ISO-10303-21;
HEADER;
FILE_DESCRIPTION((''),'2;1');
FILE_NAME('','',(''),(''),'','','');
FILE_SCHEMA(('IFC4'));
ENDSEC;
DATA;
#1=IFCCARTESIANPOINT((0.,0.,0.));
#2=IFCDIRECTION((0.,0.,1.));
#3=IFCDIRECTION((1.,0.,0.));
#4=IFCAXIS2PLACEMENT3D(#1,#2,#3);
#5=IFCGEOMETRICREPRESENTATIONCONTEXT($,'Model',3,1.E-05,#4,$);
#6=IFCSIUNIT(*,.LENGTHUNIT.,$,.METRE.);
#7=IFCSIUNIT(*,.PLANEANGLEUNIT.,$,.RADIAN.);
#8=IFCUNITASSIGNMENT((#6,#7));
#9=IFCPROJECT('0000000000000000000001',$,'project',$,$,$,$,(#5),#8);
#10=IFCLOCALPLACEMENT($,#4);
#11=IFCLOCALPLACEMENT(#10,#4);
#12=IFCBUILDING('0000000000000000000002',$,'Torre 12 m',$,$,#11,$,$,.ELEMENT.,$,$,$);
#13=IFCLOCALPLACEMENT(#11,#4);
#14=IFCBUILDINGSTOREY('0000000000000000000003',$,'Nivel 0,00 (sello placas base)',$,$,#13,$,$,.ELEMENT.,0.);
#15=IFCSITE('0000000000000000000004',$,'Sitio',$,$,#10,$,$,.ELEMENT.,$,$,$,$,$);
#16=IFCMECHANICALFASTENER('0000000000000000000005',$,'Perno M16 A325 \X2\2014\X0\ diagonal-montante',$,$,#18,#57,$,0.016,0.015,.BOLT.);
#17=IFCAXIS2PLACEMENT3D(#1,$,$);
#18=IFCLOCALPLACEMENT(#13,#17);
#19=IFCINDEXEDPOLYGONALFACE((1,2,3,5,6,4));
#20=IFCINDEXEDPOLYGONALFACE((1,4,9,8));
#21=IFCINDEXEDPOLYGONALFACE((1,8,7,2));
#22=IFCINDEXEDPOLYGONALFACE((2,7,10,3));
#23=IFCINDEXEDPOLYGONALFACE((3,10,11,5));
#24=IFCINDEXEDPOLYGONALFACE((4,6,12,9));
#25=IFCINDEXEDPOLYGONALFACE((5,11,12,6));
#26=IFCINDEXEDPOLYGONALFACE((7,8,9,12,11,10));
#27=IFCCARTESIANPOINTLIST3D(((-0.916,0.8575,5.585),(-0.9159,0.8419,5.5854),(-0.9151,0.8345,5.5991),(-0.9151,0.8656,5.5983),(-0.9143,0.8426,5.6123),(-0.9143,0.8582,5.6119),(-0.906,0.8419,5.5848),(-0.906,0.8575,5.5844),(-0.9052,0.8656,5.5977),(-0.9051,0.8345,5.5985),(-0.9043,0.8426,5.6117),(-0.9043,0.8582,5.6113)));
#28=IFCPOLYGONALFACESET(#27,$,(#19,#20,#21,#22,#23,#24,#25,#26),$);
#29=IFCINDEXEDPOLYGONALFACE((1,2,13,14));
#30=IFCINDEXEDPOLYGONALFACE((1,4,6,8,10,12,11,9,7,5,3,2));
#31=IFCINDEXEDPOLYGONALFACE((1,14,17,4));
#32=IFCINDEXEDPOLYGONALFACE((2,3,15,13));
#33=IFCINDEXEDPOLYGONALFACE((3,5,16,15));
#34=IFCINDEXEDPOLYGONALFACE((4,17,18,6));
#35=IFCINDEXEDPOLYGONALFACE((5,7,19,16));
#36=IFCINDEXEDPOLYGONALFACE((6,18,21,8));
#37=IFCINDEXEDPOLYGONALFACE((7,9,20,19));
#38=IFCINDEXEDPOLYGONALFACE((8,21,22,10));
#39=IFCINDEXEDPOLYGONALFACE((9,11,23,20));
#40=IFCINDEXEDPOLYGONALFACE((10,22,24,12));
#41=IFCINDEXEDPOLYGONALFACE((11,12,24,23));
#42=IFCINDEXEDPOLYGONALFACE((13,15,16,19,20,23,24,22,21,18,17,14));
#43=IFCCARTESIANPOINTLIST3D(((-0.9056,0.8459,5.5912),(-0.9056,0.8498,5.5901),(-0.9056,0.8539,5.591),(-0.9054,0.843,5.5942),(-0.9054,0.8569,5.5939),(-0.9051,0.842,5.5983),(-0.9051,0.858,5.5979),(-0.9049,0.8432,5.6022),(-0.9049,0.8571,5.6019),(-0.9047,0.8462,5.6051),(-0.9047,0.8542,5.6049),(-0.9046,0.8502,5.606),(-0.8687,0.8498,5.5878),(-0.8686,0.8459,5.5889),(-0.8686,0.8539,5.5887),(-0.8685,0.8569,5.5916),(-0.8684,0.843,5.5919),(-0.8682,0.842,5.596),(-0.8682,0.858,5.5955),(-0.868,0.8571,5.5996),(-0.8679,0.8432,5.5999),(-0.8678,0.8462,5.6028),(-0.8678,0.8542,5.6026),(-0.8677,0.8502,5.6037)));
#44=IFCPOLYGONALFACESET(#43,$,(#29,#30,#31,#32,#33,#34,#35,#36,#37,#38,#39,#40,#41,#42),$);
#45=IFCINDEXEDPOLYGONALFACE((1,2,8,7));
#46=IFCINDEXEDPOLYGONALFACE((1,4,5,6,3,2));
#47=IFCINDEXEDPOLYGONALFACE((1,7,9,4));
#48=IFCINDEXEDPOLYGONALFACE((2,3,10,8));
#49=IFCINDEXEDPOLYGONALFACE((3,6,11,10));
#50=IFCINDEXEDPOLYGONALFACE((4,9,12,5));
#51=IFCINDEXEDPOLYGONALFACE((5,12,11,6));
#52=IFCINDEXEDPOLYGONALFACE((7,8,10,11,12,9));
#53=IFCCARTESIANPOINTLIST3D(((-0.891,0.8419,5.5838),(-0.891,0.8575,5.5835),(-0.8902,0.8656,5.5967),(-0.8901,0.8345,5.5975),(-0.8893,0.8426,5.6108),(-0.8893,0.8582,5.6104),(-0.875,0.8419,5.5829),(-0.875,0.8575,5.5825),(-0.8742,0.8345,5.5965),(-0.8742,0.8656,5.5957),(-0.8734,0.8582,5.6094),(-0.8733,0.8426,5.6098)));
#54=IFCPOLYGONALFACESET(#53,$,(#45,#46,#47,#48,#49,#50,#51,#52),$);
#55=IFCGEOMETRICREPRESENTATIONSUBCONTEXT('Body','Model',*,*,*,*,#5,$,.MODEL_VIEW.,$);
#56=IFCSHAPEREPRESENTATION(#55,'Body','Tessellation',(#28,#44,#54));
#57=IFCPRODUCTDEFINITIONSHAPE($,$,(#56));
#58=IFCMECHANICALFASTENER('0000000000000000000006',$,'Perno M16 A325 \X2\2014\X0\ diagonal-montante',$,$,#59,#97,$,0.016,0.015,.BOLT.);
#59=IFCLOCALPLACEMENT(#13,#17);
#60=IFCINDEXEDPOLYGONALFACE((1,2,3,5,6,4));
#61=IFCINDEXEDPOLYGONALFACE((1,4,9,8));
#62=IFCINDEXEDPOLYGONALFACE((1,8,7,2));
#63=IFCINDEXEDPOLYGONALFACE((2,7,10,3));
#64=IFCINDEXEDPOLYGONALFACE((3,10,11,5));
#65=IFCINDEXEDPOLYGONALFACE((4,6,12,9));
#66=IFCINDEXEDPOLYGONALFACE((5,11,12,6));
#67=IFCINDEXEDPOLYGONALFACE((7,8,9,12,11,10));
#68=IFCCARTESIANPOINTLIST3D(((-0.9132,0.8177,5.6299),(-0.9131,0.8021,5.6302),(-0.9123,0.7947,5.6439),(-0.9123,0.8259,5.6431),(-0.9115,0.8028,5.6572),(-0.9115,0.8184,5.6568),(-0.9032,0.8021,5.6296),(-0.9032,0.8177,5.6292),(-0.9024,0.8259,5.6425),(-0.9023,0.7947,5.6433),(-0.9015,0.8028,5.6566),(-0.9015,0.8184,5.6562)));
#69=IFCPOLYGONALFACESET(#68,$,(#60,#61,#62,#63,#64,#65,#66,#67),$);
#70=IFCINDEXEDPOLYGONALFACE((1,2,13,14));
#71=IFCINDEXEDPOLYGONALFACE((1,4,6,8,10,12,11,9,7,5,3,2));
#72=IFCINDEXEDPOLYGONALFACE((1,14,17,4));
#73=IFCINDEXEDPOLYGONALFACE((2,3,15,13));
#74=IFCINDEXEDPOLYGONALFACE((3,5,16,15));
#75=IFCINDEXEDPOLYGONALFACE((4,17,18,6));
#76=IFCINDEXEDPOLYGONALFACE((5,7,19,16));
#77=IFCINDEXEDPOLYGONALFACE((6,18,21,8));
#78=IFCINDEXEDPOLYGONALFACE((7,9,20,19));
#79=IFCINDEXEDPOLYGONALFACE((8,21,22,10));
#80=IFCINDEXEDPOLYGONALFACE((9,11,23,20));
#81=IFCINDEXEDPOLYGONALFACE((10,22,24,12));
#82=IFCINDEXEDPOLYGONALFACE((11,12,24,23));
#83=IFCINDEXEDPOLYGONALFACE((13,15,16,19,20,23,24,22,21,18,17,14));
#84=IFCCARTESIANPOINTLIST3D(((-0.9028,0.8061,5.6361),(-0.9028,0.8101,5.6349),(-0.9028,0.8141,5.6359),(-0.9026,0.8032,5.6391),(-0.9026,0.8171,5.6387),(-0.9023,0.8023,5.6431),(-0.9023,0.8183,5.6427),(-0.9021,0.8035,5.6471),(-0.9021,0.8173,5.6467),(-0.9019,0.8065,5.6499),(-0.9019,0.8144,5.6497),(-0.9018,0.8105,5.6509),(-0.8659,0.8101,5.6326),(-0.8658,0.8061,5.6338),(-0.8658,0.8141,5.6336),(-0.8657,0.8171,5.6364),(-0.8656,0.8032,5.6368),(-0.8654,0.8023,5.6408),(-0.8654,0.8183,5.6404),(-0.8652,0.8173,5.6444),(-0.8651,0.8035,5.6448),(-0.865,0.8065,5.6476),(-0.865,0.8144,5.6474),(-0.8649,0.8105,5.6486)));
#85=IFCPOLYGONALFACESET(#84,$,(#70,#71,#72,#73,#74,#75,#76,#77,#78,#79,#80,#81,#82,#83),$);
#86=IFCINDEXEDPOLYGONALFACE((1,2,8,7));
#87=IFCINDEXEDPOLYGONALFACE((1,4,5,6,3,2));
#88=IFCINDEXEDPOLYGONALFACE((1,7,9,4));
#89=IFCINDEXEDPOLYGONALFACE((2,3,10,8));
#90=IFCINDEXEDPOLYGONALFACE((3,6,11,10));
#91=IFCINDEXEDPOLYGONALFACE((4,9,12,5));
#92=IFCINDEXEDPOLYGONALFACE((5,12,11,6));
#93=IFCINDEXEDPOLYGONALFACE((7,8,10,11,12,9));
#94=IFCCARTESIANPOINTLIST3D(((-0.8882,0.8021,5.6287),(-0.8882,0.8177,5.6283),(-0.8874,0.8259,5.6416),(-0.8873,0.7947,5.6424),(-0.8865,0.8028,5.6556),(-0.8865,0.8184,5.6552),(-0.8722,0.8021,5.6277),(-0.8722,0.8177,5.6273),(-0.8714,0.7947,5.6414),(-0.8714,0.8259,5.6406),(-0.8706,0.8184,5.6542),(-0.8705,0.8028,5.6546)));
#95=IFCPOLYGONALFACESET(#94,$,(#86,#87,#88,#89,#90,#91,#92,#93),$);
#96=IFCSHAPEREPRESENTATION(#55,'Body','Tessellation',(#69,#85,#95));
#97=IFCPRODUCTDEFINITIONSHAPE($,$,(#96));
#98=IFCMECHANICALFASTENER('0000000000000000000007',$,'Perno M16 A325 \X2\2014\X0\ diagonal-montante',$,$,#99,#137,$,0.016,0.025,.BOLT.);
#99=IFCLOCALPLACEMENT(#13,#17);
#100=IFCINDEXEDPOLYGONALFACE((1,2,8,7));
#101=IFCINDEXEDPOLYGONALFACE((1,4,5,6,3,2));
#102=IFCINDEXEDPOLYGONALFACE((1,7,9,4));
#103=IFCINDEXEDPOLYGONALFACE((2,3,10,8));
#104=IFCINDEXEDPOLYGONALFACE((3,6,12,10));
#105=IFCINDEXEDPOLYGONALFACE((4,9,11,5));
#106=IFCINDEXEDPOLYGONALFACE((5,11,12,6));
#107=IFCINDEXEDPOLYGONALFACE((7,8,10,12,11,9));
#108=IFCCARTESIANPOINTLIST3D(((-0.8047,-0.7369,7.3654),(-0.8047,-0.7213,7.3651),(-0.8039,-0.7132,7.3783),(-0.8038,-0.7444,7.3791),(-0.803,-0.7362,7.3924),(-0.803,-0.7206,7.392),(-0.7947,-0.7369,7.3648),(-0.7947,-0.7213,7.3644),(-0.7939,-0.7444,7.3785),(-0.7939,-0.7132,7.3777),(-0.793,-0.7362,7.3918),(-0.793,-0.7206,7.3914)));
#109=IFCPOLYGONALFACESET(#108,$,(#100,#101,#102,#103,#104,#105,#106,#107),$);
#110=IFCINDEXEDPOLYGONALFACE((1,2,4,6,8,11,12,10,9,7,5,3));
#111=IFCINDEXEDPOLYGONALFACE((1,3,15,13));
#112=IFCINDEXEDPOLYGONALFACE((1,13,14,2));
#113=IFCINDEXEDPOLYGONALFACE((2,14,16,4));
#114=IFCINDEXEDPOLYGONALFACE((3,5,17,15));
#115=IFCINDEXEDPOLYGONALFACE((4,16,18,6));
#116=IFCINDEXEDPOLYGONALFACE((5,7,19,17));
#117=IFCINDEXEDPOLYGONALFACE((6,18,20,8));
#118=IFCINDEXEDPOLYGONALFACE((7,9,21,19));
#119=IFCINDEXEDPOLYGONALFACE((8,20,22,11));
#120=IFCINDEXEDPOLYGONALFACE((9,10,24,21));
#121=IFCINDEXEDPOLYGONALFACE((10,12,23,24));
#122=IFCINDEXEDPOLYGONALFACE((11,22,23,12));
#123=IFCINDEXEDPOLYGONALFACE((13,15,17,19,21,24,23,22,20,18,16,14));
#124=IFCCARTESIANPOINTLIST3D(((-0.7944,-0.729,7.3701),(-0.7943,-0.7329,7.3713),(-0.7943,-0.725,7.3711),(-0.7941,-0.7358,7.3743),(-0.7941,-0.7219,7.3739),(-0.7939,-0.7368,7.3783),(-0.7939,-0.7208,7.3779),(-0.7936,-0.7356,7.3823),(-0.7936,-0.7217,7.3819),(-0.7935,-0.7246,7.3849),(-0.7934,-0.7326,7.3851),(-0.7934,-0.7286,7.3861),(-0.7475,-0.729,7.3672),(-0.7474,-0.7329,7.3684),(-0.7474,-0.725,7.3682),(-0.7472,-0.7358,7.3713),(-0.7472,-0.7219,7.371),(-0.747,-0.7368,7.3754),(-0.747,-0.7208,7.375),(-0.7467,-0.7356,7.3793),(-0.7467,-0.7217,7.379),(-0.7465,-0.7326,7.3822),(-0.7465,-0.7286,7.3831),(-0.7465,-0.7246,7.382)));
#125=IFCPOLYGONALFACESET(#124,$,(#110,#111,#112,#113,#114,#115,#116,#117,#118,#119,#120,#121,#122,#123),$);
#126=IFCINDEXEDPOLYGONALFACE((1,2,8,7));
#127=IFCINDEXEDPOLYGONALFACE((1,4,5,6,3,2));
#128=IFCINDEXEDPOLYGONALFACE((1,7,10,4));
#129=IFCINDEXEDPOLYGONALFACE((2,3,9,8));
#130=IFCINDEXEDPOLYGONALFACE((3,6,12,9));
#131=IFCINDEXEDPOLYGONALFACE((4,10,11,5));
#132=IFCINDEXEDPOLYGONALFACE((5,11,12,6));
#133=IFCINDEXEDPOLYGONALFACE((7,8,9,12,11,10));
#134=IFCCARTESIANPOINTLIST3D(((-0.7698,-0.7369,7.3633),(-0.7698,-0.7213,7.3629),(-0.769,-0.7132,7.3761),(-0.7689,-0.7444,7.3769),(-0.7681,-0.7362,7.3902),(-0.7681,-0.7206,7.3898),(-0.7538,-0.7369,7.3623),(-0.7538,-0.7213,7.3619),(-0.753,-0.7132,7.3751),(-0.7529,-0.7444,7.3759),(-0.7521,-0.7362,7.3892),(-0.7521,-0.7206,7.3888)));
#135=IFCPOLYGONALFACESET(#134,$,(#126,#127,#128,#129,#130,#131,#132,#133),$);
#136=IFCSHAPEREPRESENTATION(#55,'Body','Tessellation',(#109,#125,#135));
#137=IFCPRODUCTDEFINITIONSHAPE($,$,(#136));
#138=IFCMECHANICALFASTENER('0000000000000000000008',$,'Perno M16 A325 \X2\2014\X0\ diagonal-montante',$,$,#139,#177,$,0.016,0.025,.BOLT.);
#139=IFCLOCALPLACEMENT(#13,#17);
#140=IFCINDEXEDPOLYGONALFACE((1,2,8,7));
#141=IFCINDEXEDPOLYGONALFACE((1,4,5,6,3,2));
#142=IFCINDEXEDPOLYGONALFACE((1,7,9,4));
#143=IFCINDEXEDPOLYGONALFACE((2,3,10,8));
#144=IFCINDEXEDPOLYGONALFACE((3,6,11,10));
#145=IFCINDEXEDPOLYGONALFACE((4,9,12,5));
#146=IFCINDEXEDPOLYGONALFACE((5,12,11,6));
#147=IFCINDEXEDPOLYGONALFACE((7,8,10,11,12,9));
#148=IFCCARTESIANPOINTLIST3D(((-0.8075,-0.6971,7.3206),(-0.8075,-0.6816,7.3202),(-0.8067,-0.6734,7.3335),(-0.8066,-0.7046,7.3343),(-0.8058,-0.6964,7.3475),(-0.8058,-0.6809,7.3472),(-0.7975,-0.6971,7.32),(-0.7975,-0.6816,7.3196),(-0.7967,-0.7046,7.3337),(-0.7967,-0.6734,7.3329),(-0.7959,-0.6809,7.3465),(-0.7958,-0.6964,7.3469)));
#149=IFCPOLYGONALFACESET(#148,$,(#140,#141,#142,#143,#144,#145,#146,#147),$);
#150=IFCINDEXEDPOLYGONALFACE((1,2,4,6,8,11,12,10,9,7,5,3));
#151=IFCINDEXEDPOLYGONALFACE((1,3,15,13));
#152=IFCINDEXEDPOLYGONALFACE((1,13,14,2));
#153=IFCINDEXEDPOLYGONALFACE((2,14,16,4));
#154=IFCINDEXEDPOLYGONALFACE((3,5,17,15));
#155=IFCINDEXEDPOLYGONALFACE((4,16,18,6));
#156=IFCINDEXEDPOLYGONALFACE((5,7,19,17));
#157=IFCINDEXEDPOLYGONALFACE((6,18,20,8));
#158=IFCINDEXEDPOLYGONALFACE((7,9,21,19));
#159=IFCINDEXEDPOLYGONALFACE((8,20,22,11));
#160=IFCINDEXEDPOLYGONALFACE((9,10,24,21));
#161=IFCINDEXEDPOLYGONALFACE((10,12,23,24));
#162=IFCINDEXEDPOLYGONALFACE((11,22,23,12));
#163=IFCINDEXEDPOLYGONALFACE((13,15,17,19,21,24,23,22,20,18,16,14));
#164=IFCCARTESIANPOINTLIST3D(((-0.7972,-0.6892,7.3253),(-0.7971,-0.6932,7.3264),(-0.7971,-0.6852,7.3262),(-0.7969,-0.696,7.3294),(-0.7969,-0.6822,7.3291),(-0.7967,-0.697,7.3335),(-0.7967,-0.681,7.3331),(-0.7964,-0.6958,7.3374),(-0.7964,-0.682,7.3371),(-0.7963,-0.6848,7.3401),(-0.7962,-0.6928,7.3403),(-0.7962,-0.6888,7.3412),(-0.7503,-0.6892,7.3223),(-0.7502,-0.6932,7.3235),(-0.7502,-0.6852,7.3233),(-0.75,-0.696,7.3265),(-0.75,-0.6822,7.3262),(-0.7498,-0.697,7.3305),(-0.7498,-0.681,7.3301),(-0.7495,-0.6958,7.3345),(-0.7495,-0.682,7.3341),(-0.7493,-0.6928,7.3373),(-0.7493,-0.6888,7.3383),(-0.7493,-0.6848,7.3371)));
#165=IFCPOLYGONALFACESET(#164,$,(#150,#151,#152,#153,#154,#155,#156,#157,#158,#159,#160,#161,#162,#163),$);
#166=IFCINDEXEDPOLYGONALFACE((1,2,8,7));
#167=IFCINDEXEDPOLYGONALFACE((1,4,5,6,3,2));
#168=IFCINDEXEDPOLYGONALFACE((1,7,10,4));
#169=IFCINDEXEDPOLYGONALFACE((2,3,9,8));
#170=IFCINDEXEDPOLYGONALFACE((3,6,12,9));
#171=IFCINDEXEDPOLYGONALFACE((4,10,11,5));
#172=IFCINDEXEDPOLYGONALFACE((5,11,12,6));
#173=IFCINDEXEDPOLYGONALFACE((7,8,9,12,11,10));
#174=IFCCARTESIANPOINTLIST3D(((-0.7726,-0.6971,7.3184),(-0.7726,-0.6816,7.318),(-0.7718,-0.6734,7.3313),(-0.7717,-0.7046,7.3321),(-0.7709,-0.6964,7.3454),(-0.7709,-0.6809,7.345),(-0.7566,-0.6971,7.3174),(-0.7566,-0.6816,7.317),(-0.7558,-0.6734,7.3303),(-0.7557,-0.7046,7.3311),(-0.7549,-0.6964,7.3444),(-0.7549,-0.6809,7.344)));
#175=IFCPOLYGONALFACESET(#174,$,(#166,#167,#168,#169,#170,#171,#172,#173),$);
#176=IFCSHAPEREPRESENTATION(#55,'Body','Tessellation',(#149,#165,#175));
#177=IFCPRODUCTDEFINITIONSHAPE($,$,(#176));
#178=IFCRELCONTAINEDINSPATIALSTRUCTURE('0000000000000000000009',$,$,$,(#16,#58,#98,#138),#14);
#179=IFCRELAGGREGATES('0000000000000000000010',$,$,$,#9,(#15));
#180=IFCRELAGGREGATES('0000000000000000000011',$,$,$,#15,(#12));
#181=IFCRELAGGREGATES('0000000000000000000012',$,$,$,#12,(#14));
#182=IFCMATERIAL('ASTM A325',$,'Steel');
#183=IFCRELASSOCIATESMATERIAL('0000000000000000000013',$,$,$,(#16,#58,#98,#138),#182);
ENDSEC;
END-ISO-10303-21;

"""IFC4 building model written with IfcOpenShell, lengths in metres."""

from ifc_helpers import new_model, si_unit, frame, origin_with_axes, place, context, subcontext, project, spatial, polyline, outline, extrude, material, element, save


model = new_model("IFC4")

# Units and contexts
model_context = context("Model", 3, precision=1e-05, world=origin_with_axes())
body_context = subcontext(model_context, "Body", "Model", "MODEL_VIEW")
ifc_project = project(units=[si_unit("LENGTHUNIT", "METRE"), si_unit("PLANEANGLEUNIT", "RADIAN")], contexts=[model_context])

# Site, building, storey
site_placement = place(None, origin_with_axes())
site = spatial("IfcSite", under=ifc_project, at=site_placement, Name="Sitio", CompositionType="ELEMENT")
building_placement = place(site_placement, origin_with_axes())
building = spatial("IfcBuilding", under=site, at=building_placement, Name="Torre 12 m", CompositionType="ELEMENT")
storey_placement = place(building_placement, origin_with_axes())
storey = spatial("IfcBuildingStorey", under=building, at=storey_placement, Name="Nivel 0,00 (sello placas base)", CompositionType="ELEMENT", Elevation=0.0)

# Shared definitions
placement = place(storey_placement, origin_with_axes())

# Mechanical fasteners
ifc_material_1 = material(Name="ASTM A325", Category="Steel")
element("IfcMechanicalFastener", 1, at=placement, inside=storey, material=ifc_material_1, Name="Perno M16 A325 — diagonal-montante", NominalDiameter=0.016, NominalLength=0.015, PredefinedType="BOLT", context=body_context, shape_type="SweptSolid", body=[
    extrude(outline(polyline([(0.0135, 0.0078), (0.0, 0.0156), (-0.0135, 0.0078), (-0.0135, -0.0078), (0.0, -0.0156), (0.0135, -0.0078), (0.0135, 0.0078)])), frame((-0.9151, 0.85, 5.5987), z_axis=(0.998053, 0.0, -0.062378), x_axis=(0.032557, -0.85299, 0.52091)), (0.0, 0.0, 1.0), 0.01),
    extrude(outline(polyline([(0.008, 0.0), (0.0069, 0.004), (0.004, 0.0069), (0.0, 0.008), (-0.004, 0.0069), (-0.0069, 0.004), (-0.008, 0.0), (-0.0069, -0.004), (-0.004, -0.0069), (0.0, -0.008), (0.004, -0.0069), (0.0069, -0.004), (0.008, 0.0)])), frame((-0.9051, 0.85, 5.5981), z_axis=(0.998053, 0.0, -0.062378), x_axis=(0.032557, -0.85299, 0.52091)), (0.0, 0.0, 1.0), 0.037),
    extrude(outline(polyline([(0.0135, 0.0078), (0.0, 0.0156), (-0.0135, 0.0078), (-0.0135, -0.0078), (0.0, -0.0156), (0.0135, -0.0078), (0.0135, 0.0078)])), frame((-0.8902, 0.85, 5.5971), z_axis=(0.998053, 0.0, -0.062378), x_axis=(0.032557, -0.85299, 0.52091)), (0.0, 0.0, 1.0), 0.016),
])
element("IfcMechanicalFastener", 2, at=placement, inside=storey, material=ifc_material_1, Name="Perno M16 A325 — diagonal-montante", NominalDiameter=0.016, NominalLength=0.015, PredefinedType="BOLT", context=body_context, shape_type="SweptSolid", body=[
    extrude(outline(polyline([(0.0135, 0.0078), (0.0, 0.0156), (-0.0135, 0.0078), (-0.0135, -0.0078), (0.0, -0.0156), (0.0135, -0.0078), (0.0135, 0.0078)])), frame((-0.9123, 0.8103, 5.6435), z_axis=(0.998053, 0.0, -0.062378), x_axis=(0.032557, -0.85299, 0.52091)), (0.0, 0.0, 1.0), 0.01),
    extrude(outline(polyline([(0.008, 0.0), (0.0069, 0.004), (0.004, 0.0069), (0.0, 0.008), (-0.004, 0.0069), (-0.0069, 0.004), (-0.008, 0.0), (-0.0069, -0.004), (-0.004, -0.0069), (0.0, -0.008), (0.004, -0.0069), (0.0069, -0.004), (0.008, 0.0)])), frame((-0.9023, 0.8103, 5.6429), z_axis=(0.998053, 0.0, -0.062378), x_axis=(0.032557, -0.85299, 0.52091)), (0.0, 0.0, 1.0), 0.037),
    extrude(outline(polyline([(0.0135, 0.0078), (0.0, 0.0156), (-0.0135, 0.0078), (-0.0135, -0.0078), (0.0, -0.0156), (0.0135, -0.0078), (0.0135, 0.0078)])), frame((-0.8874, 0.8103, 5.642), z_axis=(0.998053, 0.0, -0.062378), x_axis=(0.032557, -0.85299, 0.52091)), (0.0, 0.0, 1.0), 0.016),
])
element("IfcMechanicalFastener", 3, at=placement, inside=storey, material=ifc_material_1, Name="Perno M16 A325 — diagonal-montante", NominalDiameter=0.016, NominalLength=0.025, PredefinedType="BOLT", context=body_context, shape_type="SweptSolid", body=[
    extrude(outline(polyline([(0.0135, 0.0078), (0.0, 0.0156), (-0.0135, 0.0078), (-0.0135, -0.0078), (0.0, -0.0156), (0.0135, -0.0078), (0.0135, 0.0078)])), frame((-0.8039, -0.7288, 7.3787), z_axis=(0.998053, 0.0, -0.062378), x_axis=(0.032557, -0.85299, 0.52091)), (0.0, 0.0, 1.0), 0.01),
    extrude(outline(polyline([(0.008, 0.0), (0.0069, 0.004), (0.004, 0.0069), (0.0, 0.008), (-0.004, 0.0069), (-0.0069, 0.004), (-0.008, 0.0), (-0.0069, -0.004), (-0.004, -0.0069), (0.0, -0.008), (0.004, -0.0069), (0.0069, -0.004), (0.008, 0.0)])), frame((-0.7939, -0.7288, 7.3781), z_axis=(0.998053, 0.0, -0.062378), x_axis=(0.032557, -0.85299, 0.52091)), (0.0, 0.0, 1.0), 0.047),
    extrude(outline(polyline([(0.0135, 0.0078), (0.0, 0.0156), (-0.0135, 0.0078), (-0.0135, -0.0078), (0.0, -0.0156), (0.0135, -0.0078), (0.0135, 0.0078)])), frame((-0.7689, -0.7288, 7.3765), z_axis=(0.998053, 0.0, -0.062378), x_axis=(0.032557, -0.85299, 0.52091)), (0.0, 0.0, 1.0), 0.016),
])
element("IfcMechanicalFastener", 4, at=placement, inside=storey, material=ifc_material_1, Name="Perno M16 A325 — diagonal-montante", NominalDiameter=0.016, NominalLength=0.025, PredefinedType="BOLT", context=body_context, shape_type="SweptSolid", body=[
    extrude(outline(polyline([(0.0135, 0.0078), (0.0, 0.0156), (-0.0135, 0.0078), (-0.0135, -0.0078), (0.0, -0.0156), (0.0135, -0.0078), (0.0135, 0.0078)])), frame((-0.8067, -0.689, 7.3339), z_axis=(0.998053, 0.0, -0.062378), x_axis=(0.032557, -0.85299, 0.52091)), (0.0, 0.0, 1.0), 0.01),
    extrude(outline(polyline([(0.008, 0.0), (0.0069, 0.004), (0.004, 0.0069), (0.0, 0.008), (-0.004, 0.0069), (-0.0069, 0.004), (-0.008, 0.0), (-0.0069, -0.004), (-0.004, -0.0069), (0.0, -0.008), (0.004, -0.0069), (0.0069, -0.004), (0.008, 0.0)])), frame((-0.7967, -0.689, 7.3333), z_axis=(0.998053, 0.0, -0.062378), x_axis=(0.032557, -0.85299, 0.52091)), (0.0, 0.0, 1.0), 0.047),
    extrude(outline(polyline([(0.0135, 0.0078), (0.0, 0.0156), (-0.0135, 0.0078), (-0.0135, -0.0078), (0.0, -0.0156), (0.0135, -0.0078), (0.0135, 0.0078)])), frame((-0.7717, -0.689, 7.3317), z_axis=(0.998053, 0.0, -0.062378), x_axis=(0.032557, -0.85299, 0.52091)), (0.0, 0.0, 1.0), 0.016),
])

save(model, "model.ifc")
